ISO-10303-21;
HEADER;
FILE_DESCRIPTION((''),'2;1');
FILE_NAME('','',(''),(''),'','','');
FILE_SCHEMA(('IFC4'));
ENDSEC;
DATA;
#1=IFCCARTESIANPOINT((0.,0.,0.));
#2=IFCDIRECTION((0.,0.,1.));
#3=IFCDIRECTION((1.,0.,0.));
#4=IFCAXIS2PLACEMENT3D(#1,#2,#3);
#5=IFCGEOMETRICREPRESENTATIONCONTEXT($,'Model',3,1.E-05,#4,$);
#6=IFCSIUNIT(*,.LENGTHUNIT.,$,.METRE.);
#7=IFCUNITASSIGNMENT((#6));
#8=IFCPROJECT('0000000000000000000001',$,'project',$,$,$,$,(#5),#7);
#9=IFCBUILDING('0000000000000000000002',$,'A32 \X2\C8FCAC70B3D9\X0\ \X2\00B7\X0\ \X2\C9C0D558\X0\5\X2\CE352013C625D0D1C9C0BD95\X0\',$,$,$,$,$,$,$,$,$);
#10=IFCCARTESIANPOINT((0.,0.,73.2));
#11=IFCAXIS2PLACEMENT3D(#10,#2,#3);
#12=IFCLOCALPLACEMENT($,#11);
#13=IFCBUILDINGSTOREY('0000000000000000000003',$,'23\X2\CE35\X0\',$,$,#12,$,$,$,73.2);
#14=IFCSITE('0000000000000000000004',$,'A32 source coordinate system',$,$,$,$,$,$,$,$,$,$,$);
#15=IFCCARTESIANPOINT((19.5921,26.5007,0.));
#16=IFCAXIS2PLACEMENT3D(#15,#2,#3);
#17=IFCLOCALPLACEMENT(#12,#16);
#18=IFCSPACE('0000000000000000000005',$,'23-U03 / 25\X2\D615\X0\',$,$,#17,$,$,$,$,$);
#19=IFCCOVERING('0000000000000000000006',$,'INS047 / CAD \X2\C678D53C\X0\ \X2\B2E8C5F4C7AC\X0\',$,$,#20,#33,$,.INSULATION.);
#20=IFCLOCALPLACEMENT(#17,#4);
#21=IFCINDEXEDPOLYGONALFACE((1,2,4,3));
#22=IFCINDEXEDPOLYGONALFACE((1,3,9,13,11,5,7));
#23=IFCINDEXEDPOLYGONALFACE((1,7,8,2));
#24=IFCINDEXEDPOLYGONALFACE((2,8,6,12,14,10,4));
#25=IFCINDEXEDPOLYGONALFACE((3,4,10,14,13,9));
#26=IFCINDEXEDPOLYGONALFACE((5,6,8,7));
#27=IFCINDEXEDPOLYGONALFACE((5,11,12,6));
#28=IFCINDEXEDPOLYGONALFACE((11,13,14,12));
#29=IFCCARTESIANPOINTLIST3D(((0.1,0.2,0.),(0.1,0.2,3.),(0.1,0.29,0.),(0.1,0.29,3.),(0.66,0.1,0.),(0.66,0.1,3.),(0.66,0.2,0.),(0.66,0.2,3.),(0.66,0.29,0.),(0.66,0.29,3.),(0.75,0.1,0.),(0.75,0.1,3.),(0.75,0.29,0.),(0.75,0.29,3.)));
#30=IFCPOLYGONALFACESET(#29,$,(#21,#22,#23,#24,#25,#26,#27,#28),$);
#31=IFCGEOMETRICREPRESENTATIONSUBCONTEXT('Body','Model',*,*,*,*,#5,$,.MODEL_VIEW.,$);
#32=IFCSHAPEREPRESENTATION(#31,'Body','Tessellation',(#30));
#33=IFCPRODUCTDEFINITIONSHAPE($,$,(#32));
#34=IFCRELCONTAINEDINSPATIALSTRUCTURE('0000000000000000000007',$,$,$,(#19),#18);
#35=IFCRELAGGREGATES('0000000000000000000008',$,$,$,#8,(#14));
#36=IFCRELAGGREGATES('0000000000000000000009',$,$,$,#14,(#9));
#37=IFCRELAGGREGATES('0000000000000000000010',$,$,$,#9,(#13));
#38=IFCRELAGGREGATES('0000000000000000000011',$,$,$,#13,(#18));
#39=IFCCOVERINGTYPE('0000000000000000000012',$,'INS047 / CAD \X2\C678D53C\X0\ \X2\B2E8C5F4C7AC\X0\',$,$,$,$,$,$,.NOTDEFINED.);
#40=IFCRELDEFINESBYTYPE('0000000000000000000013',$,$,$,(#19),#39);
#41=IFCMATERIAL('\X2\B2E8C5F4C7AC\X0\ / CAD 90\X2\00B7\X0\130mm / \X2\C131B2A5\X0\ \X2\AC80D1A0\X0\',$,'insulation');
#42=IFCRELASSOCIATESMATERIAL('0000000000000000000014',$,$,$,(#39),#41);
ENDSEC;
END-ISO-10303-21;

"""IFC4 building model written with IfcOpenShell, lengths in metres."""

from ifc_helpers import new_model, si_unit, frame, origin, origin_with_axes, place, context, subcontext, project, spatial, polyline, outline, extrude, source, transform, mapped, material, type_object, type_shapes, element, save


model = new_model("IFC4")

# Units and contexts
model_context = context("Model", 3, precision=1e-05, world=origin_with_axes())
body_context = subcontext(model_context, "Body", "Model", "MODEL_VIEW")
ifc_project = project(units=[si_unit("LENGTHUNIT", "METRE")], contexts=[model_context])

# Site, building, storey, space
storey_placement = place(None, frame((0.0, 0.0, 73.2), z_axis=(0.0, 0.0, 1.0), x_axis=(1.0, 0.0, 0.0)))
space_placement = place(storey_placement, frame((19.5921, 26.5007, 0.0), z_axis=(0.0, 0.0, 1.0), x_axis=(1.0, 0.0, 0.0)))
site = spatial("IfcSite", under=ifc_project, Name="A32 source coordinate system")
building = spatial("IfcBuilding", under=site, Name="A32 주거동 · 지하5층–옥탑지붕")
storey = spatial("IfcBuildingStorey", under=building, at=storey_placement, Name="23층", Elevation=73.2)
space = spatial("IfcSpace", under=storey, at=space_placement, Name="23-U03 / 25형")

# Covering
ifc_material = material(Name="단열재 / CAD 90·130mm / 성능 검토", Category="insulation")
covering_type_1 = type_object("IfcCoveringType", Name="INS047 / CAD 외피 단열재", PredefinedType="NOTDEFINED", material=ifc_material)
shared_shape_1 = source(origin(), body_context, "Body", "SweptSolid", [
    extrude(outline(polyline([(0.1, 0.2), (0.1, 0.29), (0.66, 0.29), (0.75, 0.29), (0.75, 0.1), (0.66, 0.1), (0.66, 0.2), (0.1, 0.2)])), origin(), (0.0, 0.0, 1.0), 3.0),
])
type_shapes(covering_type_1, [shared_shape_1])
covering_1_placement = place(space_placement, origin_with_axes())
element("IfcCovering", 1, at=covering_1_placement, inside=space, type_object=covering_type_1, Name="INS047 / CAD 외피 단열재", PredefinedType="INSULATION", context=body_context, shape_type="MappedRepresentation", body=[
    mapped(shared_shape_1, transform((0.0, 0.0, 0.0), scale=1.0)),
])

save(model, "model.ifc")
